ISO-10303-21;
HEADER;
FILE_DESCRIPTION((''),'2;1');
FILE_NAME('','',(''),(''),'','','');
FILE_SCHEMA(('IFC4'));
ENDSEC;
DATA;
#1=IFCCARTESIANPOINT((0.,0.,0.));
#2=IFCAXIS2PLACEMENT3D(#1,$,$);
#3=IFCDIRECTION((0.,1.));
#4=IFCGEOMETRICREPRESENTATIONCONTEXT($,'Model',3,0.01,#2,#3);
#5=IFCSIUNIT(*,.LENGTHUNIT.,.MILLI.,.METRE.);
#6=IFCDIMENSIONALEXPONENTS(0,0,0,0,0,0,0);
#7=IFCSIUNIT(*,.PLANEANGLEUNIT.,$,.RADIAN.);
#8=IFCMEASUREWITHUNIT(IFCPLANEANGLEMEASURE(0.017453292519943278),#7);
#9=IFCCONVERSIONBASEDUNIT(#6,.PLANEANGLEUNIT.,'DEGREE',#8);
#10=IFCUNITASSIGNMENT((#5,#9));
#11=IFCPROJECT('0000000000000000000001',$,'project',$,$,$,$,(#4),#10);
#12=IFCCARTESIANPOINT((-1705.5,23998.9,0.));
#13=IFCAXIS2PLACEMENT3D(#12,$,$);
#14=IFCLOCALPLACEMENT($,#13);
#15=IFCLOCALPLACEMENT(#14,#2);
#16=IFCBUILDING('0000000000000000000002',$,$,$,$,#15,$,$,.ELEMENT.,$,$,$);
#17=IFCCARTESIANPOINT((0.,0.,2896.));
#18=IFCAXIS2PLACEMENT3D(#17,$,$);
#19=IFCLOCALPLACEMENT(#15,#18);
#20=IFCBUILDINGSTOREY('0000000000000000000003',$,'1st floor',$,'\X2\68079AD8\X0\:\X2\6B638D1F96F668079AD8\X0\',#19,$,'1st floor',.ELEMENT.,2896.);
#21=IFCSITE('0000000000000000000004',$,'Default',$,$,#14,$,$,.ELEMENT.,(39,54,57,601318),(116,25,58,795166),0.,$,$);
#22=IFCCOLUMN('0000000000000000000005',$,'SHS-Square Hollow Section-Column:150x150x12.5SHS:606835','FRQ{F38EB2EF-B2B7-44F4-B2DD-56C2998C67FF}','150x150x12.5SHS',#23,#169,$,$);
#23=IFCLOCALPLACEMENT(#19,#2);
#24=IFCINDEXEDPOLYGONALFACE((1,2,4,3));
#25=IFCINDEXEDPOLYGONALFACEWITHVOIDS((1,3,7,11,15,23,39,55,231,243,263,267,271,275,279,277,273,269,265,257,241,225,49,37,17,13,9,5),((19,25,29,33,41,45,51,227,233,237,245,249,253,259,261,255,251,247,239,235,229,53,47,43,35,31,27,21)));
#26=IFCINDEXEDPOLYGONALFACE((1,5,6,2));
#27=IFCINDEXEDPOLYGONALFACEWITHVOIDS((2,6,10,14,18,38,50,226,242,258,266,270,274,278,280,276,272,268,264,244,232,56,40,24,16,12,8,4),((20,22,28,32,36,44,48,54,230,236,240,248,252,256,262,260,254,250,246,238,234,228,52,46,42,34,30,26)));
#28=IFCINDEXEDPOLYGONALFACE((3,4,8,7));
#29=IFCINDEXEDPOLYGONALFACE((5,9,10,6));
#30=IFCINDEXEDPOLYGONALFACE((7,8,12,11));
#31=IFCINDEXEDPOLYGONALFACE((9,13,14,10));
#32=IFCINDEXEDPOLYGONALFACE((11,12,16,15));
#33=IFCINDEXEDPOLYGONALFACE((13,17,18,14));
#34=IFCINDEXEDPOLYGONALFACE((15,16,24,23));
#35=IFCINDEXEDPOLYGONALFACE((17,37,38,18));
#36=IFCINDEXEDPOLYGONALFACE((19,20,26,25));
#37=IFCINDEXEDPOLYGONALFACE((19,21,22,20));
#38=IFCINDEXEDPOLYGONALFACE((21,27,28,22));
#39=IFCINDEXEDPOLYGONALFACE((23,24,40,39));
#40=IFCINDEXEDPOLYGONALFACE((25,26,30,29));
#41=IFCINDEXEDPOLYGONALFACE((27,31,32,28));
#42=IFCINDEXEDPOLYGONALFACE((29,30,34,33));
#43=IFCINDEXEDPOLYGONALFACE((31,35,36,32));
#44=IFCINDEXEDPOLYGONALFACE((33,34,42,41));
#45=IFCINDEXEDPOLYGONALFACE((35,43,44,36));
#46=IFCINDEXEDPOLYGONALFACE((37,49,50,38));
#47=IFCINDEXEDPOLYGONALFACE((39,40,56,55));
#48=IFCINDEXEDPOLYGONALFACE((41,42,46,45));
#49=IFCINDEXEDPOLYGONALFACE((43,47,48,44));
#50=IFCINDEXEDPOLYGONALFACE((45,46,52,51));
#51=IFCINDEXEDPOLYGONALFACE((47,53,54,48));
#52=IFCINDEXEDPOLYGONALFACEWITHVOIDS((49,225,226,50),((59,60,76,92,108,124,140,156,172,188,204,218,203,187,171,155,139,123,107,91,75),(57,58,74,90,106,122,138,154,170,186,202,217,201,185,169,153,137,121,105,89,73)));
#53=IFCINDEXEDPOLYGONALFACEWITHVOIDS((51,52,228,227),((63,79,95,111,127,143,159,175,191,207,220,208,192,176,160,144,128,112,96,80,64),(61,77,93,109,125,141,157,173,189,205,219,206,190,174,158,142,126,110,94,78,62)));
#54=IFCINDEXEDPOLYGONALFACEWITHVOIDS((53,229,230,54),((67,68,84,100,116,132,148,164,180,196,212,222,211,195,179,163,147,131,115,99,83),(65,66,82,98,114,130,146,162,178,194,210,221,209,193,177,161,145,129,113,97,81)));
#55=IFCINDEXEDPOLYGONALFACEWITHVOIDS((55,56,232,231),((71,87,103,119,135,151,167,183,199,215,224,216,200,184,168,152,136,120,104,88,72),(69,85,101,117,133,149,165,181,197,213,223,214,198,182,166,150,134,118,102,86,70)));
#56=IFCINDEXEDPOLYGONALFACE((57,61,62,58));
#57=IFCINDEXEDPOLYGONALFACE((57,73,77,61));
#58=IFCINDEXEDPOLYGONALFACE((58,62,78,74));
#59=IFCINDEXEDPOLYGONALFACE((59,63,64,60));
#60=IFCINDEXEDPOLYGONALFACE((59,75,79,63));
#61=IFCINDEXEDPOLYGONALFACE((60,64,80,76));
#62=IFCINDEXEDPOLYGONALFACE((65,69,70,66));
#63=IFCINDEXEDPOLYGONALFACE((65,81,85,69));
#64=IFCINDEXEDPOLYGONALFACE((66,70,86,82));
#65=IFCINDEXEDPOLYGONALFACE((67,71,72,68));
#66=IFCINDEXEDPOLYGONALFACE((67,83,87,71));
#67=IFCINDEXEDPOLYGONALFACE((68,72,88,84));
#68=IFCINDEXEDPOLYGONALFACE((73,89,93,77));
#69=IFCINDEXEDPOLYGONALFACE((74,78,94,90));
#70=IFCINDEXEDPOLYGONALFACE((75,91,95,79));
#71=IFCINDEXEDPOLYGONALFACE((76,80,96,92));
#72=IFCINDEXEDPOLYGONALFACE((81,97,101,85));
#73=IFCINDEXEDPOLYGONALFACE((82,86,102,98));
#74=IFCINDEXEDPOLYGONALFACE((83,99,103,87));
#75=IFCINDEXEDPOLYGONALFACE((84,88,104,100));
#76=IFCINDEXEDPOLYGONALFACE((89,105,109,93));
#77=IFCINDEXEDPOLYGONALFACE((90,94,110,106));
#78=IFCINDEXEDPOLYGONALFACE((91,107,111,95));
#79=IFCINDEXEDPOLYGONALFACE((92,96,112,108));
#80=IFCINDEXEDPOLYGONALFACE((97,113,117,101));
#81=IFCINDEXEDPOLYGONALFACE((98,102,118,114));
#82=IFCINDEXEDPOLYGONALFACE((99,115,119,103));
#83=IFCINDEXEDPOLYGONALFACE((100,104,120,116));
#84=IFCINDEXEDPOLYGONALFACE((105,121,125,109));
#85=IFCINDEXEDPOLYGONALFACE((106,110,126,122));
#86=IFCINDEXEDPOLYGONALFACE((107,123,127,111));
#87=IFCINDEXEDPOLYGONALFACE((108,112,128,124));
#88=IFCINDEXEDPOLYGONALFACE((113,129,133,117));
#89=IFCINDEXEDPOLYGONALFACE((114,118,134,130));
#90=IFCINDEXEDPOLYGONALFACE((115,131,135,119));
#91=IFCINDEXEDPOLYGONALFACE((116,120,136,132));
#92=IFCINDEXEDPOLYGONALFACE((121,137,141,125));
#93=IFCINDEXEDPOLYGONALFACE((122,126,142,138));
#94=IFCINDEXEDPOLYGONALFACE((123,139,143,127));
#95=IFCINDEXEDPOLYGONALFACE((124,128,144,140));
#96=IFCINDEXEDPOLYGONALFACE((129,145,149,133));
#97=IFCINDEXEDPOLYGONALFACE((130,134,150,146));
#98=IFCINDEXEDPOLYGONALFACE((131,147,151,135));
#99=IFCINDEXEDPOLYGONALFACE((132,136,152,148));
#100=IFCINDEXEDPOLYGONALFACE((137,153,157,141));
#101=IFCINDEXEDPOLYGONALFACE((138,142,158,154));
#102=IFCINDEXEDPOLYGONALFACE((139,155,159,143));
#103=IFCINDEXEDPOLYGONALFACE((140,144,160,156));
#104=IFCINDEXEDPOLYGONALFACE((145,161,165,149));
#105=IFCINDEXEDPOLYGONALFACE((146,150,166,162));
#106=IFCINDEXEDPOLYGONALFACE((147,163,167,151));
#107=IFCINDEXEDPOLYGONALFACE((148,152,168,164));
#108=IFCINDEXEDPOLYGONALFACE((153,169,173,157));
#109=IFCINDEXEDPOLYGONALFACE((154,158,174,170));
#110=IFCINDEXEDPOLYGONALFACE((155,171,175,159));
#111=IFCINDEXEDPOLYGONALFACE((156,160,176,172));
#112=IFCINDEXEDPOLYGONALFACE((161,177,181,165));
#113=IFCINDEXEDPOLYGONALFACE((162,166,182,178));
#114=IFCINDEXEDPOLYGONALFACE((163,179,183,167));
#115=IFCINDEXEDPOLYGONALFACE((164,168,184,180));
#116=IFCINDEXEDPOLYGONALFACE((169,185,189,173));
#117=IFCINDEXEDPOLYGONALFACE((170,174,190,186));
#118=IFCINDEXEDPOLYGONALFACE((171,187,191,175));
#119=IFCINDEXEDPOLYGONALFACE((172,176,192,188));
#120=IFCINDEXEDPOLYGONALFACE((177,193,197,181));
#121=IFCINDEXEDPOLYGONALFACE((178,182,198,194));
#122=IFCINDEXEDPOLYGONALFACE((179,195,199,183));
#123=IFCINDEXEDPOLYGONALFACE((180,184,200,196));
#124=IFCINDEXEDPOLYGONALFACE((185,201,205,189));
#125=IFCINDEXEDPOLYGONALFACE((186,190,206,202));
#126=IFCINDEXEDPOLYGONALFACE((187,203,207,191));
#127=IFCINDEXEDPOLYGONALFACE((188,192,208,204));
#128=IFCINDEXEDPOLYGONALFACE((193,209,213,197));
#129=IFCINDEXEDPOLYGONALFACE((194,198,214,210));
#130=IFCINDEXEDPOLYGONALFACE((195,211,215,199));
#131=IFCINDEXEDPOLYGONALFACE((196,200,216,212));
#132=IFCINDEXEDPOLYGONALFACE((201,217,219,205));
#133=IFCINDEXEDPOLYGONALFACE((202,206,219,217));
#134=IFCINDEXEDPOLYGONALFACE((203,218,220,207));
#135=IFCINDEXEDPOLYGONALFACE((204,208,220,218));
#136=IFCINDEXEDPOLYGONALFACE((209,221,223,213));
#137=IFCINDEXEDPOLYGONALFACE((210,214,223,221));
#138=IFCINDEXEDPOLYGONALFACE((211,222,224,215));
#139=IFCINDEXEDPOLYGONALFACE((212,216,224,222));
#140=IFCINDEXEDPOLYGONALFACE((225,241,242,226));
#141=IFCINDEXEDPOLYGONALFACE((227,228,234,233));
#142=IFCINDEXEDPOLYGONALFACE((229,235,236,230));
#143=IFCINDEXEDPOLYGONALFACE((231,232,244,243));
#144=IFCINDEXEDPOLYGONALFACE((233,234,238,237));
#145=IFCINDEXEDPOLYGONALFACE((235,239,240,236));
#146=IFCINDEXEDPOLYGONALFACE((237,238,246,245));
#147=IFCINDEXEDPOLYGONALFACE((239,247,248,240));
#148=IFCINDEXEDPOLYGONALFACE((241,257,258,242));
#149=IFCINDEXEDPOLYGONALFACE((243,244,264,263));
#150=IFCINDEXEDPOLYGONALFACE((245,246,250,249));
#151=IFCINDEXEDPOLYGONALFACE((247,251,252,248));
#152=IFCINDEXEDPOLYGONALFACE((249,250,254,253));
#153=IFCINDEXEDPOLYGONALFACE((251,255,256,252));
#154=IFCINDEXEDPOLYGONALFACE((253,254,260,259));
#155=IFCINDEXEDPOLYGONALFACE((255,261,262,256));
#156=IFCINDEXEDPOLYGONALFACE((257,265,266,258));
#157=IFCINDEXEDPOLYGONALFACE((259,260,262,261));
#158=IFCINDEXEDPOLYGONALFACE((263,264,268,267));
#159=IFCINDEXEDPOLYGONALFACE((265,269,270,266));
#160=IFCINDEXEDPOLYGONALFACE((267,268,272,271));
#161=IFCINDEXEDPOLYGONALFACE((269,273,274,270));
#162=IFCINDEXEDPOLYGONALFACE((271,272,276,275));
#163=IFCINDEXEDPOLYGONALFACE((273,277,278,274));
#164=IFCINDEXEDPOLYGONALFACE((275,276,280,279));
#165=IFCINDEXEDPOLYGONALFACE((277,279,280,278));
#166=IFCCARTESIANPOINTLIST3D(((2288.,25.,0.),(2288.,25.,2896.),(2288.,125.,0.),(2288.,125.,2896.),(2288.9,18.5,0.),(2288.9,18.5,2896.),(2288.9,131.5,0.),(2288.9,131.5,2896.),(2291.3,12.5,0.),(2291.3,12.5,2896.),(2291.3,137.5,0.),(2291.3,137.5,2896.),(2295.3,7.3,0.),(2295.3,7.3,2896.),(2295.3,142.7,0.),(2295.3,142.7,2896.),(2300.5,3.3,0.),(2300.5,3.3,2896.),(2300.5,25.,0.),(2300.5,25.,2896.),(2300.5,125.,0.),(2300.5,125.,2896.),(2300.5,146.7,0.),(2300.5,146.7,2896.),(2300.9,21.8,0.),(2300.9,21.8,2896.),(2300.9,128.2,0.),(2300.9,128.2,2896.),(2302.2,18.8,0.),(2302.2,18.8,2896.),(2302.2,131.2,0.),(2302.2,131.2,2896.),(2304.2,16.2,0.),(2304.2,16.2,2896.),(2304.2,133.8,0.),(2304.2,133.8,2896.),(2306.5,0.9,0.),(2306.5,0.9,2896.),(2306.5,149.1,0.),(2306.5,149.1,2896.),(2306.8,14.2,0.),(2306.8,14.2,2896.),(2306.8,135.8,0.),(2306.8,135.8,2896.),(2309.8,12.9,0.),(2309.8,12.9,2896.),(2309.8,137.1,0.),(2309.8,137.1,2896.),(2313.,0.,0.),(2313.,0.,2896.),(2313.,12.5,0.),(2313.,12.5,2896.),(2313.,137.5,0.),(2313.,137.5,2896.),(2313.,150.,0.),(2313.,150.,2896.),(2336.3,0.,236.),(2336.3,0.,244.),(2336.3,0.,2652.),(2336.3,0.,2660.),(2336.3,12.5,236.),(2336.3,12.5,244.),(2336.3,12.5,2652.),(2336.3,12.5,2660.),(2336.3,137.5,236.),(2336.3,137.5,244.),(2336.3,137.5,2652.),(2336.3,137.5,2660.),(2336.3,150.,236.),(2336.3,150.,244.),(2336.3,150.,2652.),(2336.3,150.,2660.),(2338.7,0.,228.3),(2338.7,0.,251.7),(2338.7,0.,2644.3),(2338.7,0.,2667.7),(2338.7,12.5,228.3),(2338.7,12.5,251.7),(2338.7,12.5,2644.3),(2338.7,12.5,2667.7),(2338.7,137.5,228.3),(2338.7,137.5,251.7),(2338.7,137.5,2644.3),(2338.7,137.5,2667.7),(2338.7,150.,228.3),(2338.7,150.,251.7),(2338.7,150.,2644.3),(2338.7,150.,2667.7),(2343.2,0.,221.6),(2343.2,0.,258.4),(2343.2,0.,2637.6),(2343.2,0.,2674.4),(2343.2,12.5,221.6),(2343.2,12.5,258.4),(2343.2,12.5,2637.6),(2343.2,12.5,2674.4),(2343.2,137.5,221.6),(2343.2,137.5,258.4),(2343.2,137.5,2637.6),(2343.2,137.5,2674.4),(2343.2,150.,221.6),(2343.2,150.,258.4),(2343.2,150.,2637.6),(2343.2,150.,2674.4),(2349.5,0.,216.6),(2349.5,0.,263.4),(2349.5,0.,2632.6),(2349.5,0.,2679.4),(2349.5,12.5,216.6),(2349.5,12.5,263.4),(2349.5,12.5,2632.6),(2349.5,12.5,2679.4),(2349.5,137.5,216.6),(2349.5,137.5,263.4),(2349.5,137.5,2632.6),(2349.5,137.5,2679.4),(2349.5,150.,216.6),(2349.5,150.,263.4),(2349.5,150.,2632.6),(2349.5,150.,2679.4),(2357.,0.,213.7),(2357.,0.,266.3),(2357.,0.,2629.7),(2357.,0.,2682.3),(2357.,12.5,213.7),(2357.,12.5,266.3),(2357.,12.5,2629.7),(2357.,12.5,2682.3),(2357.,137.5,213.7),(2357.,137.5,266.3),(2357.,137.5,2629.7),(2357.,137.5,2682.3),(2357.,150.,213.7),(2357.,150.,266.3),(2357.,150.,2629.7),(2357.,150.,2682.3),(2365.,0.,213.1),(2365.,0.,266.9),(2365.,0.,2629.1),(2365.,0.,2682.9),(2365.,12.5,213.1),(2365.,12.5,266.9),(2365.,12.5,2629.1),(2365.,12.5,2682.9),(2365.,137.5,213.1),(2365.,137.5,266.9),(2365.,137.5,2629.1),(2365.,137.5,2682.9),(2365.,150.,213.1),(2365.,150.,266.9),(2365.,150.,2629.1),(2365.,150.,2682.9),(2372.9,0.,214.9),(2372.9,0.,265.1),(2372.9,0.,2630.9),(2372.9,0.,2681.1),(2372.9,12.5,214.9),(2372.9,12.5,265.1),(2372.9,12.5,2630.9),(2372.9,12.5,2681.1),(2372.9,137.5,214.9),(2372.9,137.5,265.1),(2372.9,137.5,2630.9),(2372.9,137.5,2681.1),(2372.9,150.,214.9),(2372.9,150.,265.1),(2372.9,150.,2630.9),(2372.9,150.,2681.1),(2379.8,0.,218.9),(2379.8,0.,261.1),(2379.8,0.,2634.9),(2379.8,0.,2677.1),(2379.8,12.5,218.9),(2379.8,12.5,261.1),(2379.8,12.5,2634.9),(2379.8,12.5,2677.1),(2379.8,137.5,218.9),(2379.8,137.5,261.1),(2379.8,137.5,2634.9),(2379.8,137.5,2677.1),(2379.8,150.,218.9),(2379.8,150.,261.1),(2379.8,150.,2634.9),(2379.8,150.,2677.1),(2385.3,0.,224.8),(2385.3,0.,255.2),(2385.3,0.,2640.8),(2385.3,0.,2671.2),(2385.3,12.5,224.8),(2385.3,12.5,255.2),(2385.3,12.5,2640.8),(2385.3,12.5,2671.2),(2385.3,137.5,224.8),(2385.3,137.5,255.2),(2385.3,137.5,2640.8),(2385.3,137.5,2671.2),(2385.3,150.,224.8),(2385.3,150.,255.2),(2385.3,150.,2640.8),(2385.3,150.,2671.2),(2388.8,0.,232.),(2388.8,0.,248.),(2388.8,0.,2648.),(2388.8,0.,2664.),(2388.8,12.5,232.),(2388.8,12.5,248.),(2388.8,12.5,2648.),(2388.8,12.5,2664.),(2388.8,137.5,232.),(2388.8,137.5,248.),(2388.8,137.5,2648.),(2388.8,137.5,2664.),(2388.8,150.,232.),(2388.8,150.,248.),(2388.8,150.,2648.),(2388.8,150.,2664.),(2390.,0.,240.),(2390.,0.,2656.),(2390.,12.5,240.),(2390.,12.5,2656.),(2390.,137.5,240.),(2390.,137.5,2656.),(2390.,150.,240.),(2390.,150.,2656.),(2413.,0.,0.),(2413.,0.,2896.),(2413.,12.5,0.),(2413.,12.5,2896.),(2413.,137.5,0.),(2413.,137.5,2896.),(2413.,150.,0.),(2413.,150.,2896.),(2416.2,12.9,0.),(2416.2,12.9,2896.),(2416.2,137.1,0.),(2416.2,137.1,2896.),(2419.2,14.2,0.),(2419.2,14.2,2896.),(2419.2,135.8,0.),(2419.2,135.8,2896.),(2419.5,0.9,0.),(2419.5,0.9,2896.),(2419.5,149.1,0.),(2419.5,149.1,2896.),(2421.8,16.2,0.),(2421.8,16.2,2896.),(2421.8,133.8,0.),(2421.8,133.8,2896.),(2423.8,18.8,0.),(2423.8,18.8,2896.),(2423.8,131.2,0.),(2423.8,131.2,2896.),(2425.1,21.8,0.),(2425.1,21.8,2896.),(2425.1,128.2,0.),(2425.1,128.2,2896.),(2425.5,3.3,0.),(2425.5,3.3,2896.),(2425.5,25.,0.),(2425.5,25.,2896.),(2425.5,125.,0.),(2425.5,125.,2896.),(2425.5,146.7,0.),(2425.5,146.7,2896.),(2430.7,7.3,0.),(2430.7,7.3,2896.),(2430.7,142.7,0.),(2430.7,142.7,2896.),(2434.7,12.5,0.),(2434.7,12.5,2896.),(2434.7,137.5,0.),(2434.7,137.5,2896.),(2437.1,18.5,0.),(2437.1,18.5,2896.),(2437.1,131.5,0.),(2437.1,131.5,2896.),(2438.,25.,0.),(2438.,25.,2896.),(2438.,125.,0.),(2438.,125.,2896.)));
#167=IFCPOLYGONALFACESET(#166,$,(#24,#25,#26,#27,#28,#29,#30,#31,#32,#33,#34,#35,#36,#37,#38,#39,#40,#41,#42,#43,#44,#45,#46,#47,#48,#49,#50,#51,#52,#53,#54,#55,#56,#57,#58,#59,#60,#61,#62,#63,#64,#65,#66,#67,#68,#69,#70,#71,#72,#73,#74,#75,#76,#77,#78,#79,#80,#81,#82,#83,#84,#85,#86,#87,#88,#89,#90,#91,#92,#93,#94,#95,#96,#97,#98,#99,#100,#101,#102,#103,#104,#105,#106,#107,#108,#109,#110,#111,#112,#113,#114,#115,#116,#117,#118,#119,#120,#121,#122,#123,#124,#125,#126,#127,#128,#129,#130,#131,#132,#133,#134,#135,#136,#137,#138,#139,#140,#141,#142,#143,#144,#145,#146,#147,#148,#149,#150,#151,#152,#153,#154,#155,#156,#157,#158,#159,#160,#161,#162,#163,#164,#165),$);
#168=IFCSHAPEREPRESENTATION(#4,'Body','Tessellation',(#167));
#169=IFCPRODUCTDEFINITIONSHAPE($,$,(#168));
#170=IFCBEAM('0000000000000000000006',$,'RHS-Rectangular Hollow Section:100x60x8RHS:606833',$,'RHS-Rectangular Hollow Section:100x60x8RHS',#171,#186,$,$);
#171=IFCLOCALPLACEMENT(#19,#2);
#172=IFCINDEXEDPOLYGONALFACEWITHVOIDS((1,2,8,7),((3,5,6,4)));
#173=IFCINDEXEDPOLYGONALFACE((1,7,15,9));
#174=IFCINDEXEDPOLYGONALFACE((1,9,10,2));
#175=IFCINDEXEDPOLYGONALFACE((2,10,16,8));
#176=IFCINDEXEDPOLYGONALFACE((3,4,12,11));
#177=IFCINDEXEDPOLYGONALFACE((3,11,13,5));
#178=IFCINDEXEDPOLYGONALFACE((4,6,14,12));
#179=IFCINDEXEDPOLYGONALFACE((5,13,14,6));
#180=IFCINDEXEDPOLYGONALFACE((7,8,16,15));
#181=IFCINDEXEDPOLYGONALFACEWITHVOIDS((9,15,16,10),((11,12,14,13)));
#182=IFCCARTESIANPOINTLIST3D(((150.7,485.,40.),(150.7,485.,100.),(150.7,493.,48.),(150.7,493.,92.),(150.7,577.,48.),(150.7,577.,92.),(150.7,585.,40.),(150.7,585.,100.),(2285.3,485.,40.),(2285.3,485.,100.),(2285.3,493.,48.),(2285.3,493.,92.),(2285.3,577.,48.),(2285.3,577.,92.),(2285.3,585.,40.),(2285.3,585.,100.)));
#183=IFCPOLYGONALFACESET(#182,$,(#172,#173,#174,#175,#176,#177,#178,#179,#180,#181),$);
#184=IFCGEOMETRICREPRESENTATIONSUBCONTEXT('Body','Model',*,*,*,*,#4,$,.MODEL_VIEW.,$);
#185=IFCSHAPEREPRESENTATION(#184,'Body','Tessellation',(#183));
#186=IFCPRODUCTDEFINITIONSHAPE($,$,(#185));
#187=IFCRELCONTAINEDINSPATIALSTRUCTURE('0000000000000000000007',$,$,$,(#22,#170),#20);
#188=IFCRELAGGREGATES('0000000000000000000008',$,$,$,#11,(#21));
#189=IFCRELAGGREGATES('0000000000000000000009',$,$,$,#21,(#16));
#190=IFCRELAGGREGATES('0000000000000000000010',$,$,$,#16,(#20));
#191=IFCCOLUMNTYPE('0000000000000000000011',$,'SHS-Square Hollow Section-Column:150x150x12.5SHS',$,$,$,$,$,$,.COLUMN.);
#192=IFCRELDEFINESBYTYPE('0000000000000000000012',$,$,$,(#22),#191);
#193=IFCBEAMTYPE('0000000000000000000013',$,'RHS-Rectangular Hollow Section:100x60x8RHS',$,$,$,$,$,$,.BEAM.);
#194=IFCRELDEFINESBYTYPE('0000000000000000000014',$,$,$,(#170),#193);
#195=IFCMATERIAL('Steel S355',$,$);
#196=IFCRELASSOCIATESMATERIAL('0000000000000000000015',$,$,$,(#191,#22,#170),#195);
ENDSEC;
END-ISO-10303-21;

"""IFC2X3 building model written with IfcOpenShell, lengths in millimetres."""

from ifc_helpers import new_model, entity, si_unit, converted_unit, direction, frame, frame_2d, origin, origin_2d, place, context, subcontext, project, spatial, circle_curve, rectangle, hollow_rectangle, outline, extrude, boolean, material, type_object, element, save


model = new_model("IFC2X3")

# Units and contexts
model_context = context("Model", 3, precision=0.01, world=origin(), true_north=direction((0.0, 1.0)))
body_context = subcontext(model_context, "Body", "Model", "MODEL_VIEW")
ifc_project = project(units=[si_unit("LENGTHUNIT", "METRE", prefix="MILLI"), converted_unit("PLANEANGLEUNIT", "DEGREE", entity("IfcPlaneAngleMeasure", 0.017453292519943278), si_unit("PLANEANGLEUNIT", "RADIAN"), dimensions=[0, 0, 0, 0, 0, 0, 0])], contexts=[model_context])

# Site, building, storey
site_placement = place(None, frame((-1705.5, 23998.9, 0.0)))
site = spatial("IfcSite", under=ifc_project, at=site_placement, Name="Default", CompositionType="ELEMENT", RefLatitude=(39, 54, 57, 601318), RefLongitude=(116, 25, 58, 795166), RefElevation=0.0)
building_placement = place(site_placement, origin())
building = spatial("IfcBuilding", under=site, at=building_placement, CompositionType="ELEMENT")
storey_placement = place(building_placement, frame((0.0, 0.0, 2896.0)))
storey = spatial("IfcBuildingStorey", under=building, at=storey_placement, Name="1st floor", ObjectType="标高:正负零标高", LongName="1st floor", CompositionType="ELEMENT", Elevation=2896.0)

# Shared definitions
ifc_material_1 = material(Name="Steel S355")

# Column, openings
column_type_1 = type_object("IfcColumnType", Name="SHS-Square Hollow Section-Column:150x150x12.5SHS", PredefinedType="COLUMN", material=ifc_material_1)
column_1_placement = place(storey_placement, frame((2363.0, 75.0, 2896.0), z_axis=(0.0, 0.0, 1.0), x_axis=(0.0, -1.0, 0.0)))
column_1 = element("IfcColumn", 1, at=column_1_placement, inside=storey, type_object=column_type_1, material=ifc_material_1, Name="SHS-Square Hollow Section-Column:150x150x12.5SHS:606835", Description="FRQ{F38EB2EF-B2B7-44F4-B2DD-56C2998C67FF}", ObjectType="150x150x12.5SHS", context=model_context, shape_type="SweptSolid", body=[
    extrude(hollow_rectangle(XDim=150.0, YDim=150.0, WallThickness=12.5, InnerFilletRadius=12.5, OuterFilletRadius=25.0, at=origin_2d()), origin(), (0.0, 0.0, -1.0), 2896.0),
])
opening_1_placement = place(column_1_placement, frame((-175.1, 0.0, 0.0), z_axis=(1.0, 0.0, 0.0), x_axis=(0.0, 1.0, 0.0)))
element("IfcOpeningElement", 2, at=opening_1_placement, cuts=column_1, ObjectType="Opening", context=model_context, shape_type="SweptSolid", body=[
    extrude(outline(circle_curve(frame_2d((0.0, -240.0), x_axis=(1.0, 0.0)), 27.0)), origin(), (0.0, 0.0, 1.0), 350.2),
])
opening_2_placement = place(column_1_placement, frame((-175.1, 0.0, -2896.0), z_axis=(1.0, 0.0, 0.0), x_axis=(0.0, 1.0, 0.0)))
element("IfcOpeningElement", 3, at=opening_2_placement, cuts=column_1, ObjectType="Opening", context=model_context, shape_type="SweptSolid", body=[
    extrude(outline(circle_curve(frame_2d((0.0, 240.0), x_axis=(1.0, 0.0)), 27.0)), origin(), (0.0, 0.0, 1.0), 350.2),
])

# Beam
beam_type_1 = type_object("IfcBeamType", Name="RHS-Rectangular Hollow Section:100x60x8RHS", PredefinedType="BEAM")
beam_1_placement = place(storey_placement, frame((150.7, 585.0, 70.0)))
element("IfcBeam", 4, at=beam_1_placement, inside=storey, type_object=beam_type_1, material=ifc_material_1, Name="RHS-Rectangular Hollow Section:100x60x8RHS:606833", ObjectType="RHS-Rectangular Hollow Section:100x60x8RHS", context=body_context, shape_type="SweptSolid", body=[
    boolean("DIFFERENCE", extrude(rectangle(XDim=60.0, YDim=100.0, at=frame_2d((0.0, 0.0), x_axis=(1.0, 0.0))), frame((0.0, -50.0, 0.0), z_axis=(1.0, 0.0, 0.0), x_axis=(0.0, 0.0, -1.0)), (0.0, 0.0, 1.0), 2134.6), extrude(rectangle(XDim=44.0, YDim=84.0, at=frame_2d((0.0, 0.0), x_axis=(0.0, 1.0))), frame((2134.6, -50.0, 0.0), z_axis=(-1.0, 0.0, 0.0), x_axis=(0.0, 1.0, 0.0)), (0.0, 0.0, 1.0), 2134.6)),
])

save(model, "model.ifc")
